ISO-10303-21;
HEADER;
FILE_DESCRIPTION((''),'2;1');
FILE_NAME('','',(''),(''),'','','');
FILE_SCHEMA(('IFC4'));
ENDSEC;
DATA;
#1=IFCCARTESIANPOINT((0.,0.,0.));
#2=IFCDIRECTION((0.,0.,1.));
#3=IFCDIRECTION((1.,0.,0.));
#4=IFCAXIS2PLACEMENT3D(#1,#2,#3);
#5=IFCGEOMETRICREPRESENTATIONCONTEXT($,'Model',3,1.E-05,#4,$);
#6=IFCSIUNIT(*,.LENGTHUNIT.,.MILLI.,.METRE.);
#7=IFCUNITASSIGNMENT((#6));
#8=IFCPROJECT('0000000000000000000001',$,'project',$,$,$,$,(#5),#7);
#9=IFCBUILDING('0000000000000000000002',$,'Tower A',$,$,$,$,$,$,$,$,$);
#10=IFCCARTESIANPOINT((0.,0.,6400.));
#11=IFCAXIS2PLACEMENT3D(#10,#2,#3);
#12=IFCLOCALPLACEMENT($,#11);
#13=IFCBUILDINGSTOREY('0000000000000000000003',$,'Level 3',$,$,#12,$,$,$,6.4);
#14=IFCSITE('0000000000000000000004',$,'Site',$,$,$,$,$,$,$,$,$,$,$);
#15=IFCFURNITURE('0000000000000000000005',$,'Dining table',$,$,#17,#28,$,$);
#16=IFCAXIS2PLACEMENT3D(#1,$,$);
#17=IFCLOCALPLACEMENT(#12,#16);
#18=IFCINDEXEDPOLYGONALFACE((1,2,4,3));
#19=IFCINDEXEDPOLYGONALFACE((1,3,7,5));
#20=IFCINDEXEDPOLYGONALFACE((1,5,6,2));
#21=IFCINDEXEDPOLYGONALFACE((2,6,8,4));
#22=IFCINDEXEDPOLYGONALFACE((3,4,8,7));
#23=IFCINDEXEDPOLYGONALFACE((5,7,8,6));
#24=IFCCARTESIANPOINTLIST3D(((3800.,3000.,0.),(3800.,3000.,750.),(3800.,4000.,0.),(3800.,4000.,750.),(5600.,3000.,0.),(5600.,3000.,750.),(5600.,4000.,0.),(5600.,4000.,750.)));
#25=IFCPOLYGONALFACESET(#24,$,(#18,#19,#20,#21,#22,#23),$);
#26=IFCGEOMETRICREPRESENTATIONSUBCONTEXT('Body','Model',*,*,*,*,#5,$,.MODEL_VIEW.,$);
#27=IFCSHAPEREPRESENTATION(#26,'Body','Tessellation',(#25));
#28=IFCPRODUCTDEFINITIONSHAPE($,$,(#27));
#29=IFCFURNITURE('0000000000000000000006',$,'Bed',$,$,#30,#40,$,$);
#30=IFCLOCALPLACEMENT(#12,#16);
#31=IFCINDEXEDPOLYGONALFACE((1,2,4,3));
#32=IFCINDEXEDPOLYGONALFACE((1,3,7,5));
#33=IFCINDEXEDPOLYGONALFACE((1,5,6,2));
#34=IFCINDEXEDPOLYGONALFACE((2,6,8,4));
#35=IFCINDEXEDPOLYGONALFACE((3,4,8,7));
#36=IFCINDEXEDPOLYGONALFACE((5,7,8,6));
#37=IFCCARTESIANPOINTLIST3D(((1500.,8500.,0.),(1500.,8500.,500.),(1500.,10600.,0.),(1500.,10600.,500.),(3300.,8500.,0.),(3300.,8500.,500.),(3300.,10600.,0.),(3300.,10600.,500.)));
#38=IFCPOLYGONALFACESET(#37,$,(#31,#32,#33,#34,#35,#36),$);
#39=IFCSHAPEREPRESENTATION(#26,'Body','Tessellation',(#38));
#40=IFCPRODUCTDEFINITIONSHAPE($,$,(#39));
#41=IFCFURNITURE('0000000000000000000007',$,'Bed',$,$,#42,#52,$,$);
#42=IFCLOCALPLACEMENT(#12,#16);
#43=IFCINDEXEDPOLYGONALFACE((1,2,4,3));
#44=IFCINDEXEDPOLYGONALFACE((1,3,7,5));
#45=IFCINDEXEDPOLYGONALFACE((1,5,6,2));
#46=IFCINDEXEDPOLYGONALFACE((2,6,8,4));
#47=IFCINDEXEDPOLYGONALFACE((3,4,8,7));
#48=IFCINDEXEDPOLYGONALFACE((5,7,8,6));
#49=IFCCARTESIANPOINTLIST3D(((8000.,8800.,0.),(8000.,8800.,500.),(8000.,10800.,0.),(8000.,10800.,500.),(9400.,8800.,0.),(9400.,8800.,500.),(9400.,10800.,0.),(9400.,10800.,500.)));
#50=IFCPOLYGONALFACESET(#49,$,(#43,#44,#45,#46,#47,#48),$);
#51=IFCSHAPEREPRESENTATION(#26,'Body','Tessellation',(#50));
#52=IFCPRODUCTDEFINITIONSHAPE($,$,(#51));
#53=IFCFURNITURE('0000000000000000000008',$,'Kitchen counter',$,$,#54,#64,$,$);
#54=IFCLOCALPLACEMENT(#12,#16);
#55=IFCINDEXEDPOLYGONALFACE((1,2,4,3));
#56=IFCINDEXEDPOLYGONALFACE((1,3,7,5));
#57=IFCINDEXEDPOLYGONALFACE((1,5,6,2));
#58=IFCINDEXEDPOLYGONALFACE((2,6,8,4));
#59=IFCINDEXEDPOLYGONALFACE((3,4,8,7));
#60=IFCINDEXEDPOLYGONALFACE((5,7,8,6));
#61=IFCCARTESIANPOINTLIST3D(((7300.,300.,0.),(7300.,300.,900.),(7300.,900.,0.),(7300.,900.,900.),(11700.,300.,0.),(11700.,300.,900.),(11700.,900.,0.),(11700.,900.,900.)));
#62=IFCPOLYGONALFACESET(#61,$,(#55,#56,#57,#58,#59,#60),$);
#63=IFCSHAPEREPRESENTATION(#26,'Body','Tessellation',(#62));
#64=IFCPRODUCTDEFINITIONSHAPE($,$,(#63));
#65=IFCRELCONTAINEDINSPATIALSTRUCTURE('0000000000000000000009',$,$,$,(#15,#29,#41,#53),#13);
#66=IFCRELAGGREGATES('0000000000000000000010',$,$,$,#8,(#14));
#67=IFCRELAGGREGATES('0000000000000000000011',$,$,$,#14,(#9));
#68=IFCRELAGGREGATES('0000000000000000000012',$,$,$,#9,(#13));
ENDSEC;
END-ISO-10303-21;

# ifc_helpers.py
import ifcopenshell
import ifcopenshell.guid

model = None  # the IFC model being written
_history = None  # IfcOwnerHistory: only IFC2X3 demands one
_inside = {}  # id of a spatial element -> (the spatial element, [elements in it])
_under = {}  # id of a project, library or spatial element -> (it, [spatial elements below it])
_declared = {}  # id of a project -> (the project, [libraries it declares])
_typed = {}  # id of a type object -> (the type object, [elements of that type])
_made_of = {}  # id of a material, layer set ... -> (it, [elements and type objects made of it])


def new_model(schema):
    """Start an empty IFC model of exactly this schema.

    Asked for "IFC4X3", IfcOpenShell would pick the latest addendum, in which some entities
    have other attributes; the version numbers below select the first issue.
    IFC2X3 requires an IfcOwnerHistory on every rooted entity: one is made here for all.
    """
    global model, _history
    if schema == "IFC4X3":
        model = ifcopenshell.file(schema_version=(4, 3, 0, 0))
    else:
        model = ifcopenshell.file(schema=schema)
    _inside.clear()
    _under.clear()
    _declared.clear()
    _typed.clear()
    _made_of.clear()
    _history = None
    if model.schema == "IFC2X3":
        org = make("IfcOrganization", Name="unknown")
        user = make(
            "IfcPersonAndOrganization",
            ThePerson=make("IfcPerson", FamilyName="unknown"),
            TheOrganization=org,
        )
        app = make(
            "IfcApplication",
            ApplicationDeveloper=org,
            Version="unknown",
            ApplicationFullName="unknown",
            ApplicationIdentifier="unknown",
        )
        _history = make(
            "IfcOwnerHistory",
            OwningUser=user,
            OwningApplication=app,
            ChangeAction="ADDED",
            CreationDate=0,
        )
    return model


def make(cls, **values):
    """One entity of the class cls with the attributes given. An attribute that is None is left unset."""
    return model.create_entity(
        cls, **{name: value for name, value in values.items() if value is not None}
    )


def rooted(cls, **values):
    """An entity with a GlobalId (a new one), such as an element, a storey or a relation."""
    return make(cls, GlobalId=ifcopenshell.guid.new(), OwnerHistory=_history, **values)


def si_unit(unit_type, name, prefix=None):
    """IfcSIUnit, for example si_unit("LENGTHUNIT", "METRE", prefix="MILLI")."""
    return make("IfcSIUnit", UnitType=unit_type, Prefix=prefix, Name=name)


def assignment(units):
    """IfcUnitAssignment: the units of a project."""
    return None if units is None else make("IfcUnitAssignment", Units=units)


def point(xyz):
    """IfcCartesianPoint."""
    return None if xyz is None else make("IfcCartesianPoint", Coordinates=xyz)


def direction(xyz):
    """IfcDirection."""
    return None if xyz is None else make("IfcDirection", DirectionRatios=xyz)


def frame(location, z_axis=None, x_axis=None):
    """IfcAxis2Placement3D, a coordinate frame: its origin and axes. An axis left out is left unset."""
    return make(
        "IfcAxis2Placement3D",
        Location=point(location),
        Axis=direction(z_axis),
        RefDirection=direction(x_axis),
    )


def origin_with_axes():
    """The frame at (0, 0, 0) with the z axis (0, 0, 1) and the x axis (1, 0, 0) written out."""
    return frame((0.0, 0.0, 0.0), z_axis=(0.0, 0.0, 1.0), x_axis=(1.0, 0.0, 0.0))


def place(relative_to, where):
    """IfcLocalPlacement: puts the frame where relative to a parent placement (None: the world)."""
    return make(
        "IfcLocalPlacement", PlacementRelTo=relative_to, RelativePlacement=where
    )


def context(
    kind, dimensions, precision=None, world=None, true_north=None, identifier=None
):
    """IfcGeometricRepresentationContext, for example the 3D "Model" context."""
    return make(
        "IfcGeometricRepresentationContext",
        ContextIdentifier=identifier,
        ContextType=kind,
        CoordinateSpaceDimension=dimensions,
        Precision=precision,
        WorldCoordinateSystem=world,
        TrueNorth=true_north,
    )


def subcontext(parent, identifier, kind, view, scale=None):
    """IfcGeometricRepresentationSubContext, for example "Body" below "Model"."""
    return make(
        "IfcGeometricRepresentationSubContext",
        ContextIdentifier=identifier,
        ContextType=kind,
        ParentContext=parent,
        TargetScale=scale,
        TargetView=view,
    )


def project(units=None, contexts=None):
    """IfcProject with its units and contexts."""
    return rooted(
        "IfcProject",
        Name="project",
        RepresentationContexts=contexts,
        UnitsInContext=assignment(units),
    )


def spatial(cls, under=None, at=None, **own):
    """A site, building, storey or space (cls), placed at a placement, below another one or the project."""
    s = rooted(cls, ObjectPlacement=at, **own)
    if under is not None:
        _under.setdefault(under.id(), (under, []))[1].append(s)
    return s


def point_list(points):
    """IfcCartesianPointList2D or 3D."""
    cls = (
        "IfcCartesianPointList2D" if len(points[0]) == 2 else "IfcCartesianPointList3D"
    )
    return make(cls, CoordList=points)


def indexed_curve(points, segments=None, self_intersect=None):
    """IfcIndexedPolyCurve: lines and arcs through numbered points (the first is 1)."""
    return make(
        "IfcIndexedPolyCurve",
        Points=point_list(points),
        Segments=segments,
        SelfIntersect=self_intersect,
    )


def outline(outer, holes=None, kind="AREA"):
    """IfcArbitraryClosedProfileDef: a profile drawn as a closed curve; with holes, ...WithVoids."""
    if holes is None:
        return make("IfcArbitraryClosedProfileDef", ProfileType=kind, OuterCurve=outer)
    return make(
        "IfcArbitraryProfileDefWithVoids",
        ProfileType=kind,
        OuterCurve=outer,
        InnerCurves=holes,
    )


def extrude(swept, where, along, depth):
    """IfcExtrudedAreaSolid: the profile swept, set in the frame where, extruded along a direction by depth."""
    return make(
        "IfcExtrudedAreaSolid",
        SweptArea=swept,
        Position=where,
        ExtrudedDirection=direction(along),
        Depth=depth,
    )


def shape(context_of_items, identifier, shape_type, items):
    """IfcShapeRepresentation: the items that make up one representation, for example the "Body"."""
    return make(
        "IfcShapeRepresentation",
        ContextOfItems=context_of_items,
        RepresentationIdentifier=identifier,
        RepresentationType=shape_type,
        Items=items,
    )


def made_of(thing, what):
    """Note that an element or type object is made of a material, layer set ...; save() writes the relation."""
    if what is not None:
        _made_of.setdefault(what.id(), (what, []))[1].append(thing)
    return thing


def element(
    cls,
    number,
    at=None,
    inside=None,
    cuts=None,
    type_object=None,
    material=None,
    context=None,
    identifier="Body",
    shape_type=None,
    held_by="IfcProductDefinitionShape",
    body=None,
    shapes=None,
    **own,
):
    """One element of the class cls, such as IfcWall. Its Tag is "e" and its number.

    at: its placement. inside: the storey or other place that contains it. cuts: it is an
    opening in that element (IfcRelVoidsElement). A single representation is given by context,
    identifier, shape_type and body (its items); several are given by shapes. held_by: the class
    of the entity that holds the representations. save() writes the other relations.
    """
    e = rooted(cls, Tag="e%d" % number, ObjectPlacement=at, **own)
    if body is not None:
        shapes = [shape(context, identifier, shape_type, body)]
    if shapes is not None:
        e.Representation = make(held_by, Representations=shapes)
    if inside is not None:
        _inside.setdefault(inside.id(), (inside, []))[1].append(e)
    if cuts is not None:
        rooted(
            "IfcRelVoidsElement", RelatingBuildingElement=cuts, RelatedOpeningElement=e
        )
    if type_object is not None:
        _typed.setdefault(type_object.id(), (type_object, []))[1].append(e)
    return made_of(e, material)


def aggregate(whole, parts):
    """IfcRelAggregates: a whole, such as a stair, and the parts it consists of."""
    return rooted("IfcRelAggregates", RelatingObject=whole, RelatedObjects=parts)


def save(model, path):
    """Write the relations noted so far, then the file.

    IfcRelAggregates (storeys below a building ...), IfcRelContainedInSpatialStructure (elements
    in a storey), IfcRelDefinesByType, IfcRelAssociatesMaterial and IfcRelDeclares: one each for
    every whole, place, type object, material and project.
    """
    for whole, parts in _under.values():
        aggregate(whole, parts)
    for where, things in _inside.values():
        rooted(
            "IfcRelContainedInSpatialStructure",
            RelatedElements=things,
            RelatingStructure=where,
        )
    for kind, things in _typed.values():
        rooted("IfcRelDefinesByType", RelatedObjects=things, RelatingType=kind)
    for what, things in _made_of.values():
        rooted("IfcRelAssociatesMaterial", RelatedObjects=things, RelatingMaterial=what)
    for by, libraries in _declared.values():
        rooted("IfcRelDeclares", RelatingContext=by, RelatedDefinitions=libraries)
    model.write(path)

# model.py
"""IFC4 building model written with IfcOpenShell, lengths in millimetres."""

from ifc_helpers import new_model, si_unit, frame, origin_with_axes, place, context, subcontext, project, spatial, indexed_curve, outline, extrude, element, save


model = new_model("IFC4")

# Units and contexts
model_context = context("Model", 3, precision=1e-05, world=origin_with_axes())
body_context = subcontext(model_context, "Body", "Model", "MODEL_VIEW")
ifc_project = project(units=[si_unit("LENGTHUNIT", "METRE", prefix="MILLI")], contexts=[model_context])

# Site, building, storey
site = spatial("IfcSite", under=ifc_project, Name="Site")
building = spatial("IfcBuilding", under=site, Name="Tower A")
storey_placement = place(None, frame((0.0, 0.0, 6400.0), z_axis=(0.0, 0.0, 1.0), x_axis=(1.0, 0.0, 0.0)))
storey = spatial("IfcBuildingStorey", under=building, at=storey_placement, Name="Level 3", Elevation=6.4)

# Furniture
furniture_1_placement = place(storey_placement, frame((3800.0, 3000.0, 0.0), z_axis=(0.0, 0.0, 1.0), x_axis=(1.0, 0.0, 0.0)))
element("IfcFurniture", 1, at=furniture_1_placement, inside=storey, Name="Dining table", context=body_context, shape_type="SweptSolid", body=[
    extrude(outline(indexed_curve([(0.0, 0.0), (1800.0, 0.0), (1800.0, 1000.0), (0.0, 1000.0)])), None, (0.0, 0.0, 1.0), 750.0),
])
furniture_2_placement = place(storey_placement, frame((1500.0, 8500.0, 0.0), z_axis=(0.0, 0.0, 1.0), x_axis=(1.0, 0.0, 0.0)))
element("IfcFurniture", 2, at=furniture_2_placement, inside=storey, Name="Bed", context=body_context, shape_type="SweptSolid", body=[
    extrude(outline(indexed_curve([(0.0, 0.0), (1800.0, 0.0), (1800.0, 2100.0), (0.0, 2100.0)])), None, (0.0, 0.0, 1.0), 500.0),
])
furniture_3_placement = place(storey_placement, frame((8000.0, 8800.0, 0.0), z_axis=(0.0, 0.0, 1.0), x_axis=(1.0, 0.0, 0.0)))
element("IfcFurniture", 3, at=furniture_3_placement, inside=storey, Name="Bed", context=body_context, shape_type="SweptSolid", body=[
    extrude(outline(indexed_curve([(0.0, 0.0), (1400.0, 0.0), (1400.0, 2000.0), (0.0, 2000.0)])), None, (0.0, 0.0, 1.0), 500.0),
])
furniture_4_placement = place(storey_placement, frame((7300.0, 300.0, 0.0), z_axis=(0.0, 0.0, 1.0), x_axis=(1.0, 0.0, 0.0)))
element("IfcFurniture", 4, at=furniture_4_placement, inside=storey, Name="Kitchen counter", context=body_context, shape_type="SweptSolid", body=[
    extrude(outline(indexed_curve([(0.0, 0.0), (4400.0, 0.0), (4400.0, 600.0), (0.0, 600.0)])), None, (0.0, 0.0, 1.0), 900.0),
])

save(model, "model.ifc")
